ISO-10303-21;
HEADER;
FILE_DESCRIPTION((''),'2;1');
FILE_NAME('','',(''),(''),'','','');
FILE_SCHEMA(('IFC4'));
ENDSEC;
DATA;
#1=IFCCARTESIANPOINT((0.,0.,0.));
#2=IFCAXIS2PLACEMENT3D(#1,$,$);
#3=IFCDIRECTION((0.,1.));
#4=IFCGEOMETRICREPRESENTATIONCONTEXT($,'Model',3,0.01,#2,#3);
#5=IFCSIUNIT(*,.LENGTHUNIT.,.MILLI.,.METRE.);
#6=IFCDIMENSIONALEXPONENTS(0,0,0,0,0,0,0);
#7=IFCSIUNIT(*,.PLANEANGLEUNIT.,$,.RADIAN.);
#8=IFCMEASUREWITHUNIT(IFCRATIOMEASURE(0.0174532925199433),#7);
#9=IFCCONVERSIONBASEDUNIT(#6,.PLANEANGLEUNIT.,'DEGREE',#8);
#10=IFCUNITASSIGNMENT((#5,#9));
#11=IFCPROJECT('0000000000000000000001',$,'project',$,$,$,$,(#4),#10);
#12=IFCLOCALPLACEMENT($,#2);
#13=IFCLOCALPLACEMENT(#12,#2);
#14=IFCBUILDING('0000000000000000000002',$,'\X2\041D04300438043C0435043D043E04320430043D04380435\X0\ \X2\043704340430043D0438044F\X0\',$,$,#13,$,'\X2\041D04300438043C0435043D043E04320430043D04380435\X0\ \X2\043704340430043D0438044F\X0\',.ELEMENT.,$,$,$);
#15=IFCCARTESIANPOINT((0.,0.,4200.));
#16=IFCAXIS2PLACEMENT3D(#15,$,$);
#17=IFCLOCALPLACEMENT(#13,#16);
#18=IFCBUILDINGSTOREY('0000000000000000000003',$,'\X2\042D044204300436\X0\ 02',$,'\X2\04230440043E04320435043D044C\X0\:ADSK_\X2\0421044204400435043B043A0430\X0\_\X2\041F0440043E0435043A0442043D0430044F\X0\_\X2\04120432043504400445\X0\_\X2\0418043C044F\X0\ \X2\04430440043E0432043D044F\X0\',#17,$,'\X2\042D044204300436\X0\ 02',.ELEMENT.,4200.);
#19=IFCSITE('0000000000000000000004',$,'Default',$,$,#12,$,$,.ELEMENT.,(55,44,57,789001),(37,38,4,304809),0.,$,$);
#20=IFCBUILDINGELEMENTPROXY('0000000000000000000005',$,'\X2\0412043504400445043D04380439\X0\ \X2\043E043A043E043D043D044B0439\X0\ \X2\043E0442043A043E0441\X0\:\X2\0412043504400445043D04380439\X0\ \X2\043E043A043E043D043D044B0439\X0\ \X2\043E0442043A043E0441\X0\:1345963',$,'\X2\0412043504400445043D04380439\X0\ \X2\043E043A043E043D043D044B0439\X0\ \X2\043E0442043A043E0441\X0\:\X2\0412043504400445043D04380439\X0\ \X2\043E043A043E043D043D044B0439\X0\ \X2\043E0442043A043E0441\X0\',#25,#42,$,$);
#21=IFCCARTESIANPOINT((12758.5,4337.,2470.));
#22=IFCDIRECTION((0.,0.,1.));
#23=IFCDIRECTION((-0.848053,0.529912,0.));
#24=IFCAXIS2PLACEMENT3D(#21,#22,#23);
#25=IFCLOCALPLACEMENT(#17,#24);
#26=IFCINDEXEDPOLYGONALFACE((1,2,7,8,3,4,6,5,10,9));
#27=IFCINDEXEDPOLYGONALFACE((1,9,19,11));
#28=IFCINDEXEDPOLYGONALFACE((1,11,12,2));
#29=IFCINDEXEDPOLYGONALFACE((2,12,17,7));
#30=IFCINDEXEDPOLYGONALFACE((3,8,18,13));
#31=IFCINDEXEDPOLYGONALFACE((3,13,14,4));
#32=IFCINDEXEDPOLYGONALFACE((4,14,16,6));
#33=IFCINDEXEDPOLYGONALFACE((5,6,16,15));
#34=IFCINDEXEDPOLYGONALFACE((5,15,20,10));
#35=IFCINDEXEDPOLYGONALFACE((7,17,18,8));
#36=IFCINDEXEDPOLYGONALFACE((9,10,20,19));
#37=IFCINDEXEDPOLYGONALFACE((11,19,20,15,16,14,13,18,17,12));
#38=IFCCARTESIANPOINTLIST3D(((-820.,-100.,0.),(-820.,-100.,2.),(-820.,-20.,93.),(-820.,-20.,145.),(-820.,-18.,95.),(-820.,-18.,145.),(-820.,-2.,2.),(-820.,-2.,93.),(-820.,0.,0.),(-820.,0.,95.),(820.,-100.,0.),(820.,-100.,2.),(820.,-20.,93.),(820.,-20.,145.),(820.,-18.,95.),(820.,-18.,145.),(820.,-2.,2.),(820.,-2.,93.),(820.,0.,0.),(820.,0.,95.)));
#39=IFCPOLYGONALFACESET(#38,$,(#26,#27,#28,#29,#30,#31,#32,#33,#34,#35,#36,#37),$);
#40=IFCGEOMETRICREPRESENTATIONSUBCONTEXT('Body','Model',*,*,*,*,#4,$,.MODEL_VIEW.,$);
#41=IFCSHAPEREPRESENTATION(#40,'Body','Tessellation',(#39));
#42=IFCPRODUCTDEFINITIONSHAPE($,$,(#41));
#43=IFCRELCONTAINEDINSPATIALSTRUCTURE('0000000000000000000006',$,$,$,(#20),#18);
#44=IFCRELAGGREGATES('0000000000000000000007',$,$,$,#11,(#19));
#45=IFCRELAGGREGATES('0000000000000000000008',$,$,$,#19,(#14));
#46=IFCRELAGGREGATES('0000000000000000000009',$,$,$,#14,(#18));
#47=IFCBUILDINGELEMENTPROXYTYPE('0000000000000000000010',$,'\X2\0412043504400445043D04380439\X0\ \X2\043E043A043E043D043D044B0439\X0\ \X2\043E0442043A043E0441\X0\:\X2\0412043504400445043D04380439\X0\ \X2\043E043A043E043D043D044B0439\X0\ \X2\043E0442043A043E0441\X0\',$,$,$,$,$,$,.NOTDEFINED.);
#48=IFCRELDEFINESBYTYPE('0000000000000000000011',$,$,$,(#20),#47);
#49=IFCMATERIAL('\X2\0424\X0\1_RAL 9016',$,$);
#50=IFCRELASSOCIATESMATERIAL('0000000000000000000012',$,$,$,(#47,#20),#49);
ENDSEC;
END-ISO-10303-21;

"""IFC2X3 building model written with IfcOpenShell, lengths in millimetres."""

from ifc_helpers import new_model, entity, si_unit, converted_unit, direction, frame, origin, place, context, subcontext, project, spatial, polyline, outline, extrude, source, transform, mapped, material, type_object, type_shapes, element, save


model = new_model("IFC2X3")

# Units and contexts
model_context = context("Model", 3, precision=0.01, world=origin(), true_north=direction((0.0, 1.0)))
body_context = subcontext(model_context, "Body", "Model", "MODEL_VIEW")
ifc_project = project(units=[si_unit("LENGTHUNIT", "METRE", prefix="MILLI"), converted_unit("PLANEANGLEUNIT", "DEGREE", entity("IfcRatioMeasure", 0.0174532925199433), si_unit("PLANEANGLEUNIT", "RADIAN"), dimensions=[0, 0, 0, 0, 0, 0, 0])], contexts=[model_context])

# Site, building, storey
site_placement = place(None, origin())
site = spatial("IfcSite", under=ifc_project, at=site_placement, Name="Default", CompositionType="ELEMENT", RefLatitude=(55, 44, 57, 789001), RefLongitude=(37, 38, 4, 304809), RefElevation=0.0)
building_placement = place(site_placement, origin())
building = spatial("IfcBuilding", under=site, at=building_placement, Name="Наименование здания", LongName="Наименование здания", CompositionType="ELEMENT")
storey_placement = place(building_placement, frame((0.0, 0.0, 4200.0)))
storey = spatial("IfcBuildingStorey", under=building, at=storey_placement, Name="Этаж 02", ObjectType="Уровень:ADSK_Стрелка_Проектная_Вверх_Имя уровня", LongName="Этаж 02", CompositionType="ELEMENT", Elevation=4200.0)

# Building element proxy
ifc_material_1 = material(Name="Ф1_RAL 9016")
building_element_proxy_type_1 = type_object("IfcBuildingElementProxyType", Name="Верхний оконный откос:Верхний оконный откос", PredefinedType="NOTDEFINED", material=ifc_material_1)
shared_shape_1 = source(origin(), body_context, "Body", "SweptSolid", [
    extrude(outline(polyline([(28.0, -10.0), (78.0, -10.0), (78.0, -8.0), (26.0, -8.0), (26.0, -26.0), (-65.0, -26.0), (-65.0, 72.0), (-67.0, 72.0), (-67.0, -28.0), (28.0, -28.0), (28.0, -10.0)])), frame((-820.0, -28.0, 67.0), z_axis=(1.0, 0.0, 0.0), x_axis=(0.0, 0.0, 1.0)), (0.0, 0.0, 1.0), 1640.0),
])
type_shapes(building_element_proxy_type_1, [shared_shape_1])
proxy_1_placement = place(storey_placement, frame((12758.5, 4337.0, 2470.0), z_axis=(0.0, 0.0, 1.0), x_axis=(-0.848053, 0.529912, 0.0)))
element("IfcBuildingElementProxy", 1, at=proxy_1_placement, inside=storey, type_object=building_element_proxy_type_1, material=ifc_material_1, Name="Верхний оконный откос:Верхний оконный откос:1345963", ObjectType="Верхний оконный откос:Верхний оконный откос", context=body_context, shape_type="MappedRepresentation", body=[
    mapped(shared_shape_1, transform((0.0, 0.0, 0.0), scale=1.0)),
])

save(model, "model.ifc")
